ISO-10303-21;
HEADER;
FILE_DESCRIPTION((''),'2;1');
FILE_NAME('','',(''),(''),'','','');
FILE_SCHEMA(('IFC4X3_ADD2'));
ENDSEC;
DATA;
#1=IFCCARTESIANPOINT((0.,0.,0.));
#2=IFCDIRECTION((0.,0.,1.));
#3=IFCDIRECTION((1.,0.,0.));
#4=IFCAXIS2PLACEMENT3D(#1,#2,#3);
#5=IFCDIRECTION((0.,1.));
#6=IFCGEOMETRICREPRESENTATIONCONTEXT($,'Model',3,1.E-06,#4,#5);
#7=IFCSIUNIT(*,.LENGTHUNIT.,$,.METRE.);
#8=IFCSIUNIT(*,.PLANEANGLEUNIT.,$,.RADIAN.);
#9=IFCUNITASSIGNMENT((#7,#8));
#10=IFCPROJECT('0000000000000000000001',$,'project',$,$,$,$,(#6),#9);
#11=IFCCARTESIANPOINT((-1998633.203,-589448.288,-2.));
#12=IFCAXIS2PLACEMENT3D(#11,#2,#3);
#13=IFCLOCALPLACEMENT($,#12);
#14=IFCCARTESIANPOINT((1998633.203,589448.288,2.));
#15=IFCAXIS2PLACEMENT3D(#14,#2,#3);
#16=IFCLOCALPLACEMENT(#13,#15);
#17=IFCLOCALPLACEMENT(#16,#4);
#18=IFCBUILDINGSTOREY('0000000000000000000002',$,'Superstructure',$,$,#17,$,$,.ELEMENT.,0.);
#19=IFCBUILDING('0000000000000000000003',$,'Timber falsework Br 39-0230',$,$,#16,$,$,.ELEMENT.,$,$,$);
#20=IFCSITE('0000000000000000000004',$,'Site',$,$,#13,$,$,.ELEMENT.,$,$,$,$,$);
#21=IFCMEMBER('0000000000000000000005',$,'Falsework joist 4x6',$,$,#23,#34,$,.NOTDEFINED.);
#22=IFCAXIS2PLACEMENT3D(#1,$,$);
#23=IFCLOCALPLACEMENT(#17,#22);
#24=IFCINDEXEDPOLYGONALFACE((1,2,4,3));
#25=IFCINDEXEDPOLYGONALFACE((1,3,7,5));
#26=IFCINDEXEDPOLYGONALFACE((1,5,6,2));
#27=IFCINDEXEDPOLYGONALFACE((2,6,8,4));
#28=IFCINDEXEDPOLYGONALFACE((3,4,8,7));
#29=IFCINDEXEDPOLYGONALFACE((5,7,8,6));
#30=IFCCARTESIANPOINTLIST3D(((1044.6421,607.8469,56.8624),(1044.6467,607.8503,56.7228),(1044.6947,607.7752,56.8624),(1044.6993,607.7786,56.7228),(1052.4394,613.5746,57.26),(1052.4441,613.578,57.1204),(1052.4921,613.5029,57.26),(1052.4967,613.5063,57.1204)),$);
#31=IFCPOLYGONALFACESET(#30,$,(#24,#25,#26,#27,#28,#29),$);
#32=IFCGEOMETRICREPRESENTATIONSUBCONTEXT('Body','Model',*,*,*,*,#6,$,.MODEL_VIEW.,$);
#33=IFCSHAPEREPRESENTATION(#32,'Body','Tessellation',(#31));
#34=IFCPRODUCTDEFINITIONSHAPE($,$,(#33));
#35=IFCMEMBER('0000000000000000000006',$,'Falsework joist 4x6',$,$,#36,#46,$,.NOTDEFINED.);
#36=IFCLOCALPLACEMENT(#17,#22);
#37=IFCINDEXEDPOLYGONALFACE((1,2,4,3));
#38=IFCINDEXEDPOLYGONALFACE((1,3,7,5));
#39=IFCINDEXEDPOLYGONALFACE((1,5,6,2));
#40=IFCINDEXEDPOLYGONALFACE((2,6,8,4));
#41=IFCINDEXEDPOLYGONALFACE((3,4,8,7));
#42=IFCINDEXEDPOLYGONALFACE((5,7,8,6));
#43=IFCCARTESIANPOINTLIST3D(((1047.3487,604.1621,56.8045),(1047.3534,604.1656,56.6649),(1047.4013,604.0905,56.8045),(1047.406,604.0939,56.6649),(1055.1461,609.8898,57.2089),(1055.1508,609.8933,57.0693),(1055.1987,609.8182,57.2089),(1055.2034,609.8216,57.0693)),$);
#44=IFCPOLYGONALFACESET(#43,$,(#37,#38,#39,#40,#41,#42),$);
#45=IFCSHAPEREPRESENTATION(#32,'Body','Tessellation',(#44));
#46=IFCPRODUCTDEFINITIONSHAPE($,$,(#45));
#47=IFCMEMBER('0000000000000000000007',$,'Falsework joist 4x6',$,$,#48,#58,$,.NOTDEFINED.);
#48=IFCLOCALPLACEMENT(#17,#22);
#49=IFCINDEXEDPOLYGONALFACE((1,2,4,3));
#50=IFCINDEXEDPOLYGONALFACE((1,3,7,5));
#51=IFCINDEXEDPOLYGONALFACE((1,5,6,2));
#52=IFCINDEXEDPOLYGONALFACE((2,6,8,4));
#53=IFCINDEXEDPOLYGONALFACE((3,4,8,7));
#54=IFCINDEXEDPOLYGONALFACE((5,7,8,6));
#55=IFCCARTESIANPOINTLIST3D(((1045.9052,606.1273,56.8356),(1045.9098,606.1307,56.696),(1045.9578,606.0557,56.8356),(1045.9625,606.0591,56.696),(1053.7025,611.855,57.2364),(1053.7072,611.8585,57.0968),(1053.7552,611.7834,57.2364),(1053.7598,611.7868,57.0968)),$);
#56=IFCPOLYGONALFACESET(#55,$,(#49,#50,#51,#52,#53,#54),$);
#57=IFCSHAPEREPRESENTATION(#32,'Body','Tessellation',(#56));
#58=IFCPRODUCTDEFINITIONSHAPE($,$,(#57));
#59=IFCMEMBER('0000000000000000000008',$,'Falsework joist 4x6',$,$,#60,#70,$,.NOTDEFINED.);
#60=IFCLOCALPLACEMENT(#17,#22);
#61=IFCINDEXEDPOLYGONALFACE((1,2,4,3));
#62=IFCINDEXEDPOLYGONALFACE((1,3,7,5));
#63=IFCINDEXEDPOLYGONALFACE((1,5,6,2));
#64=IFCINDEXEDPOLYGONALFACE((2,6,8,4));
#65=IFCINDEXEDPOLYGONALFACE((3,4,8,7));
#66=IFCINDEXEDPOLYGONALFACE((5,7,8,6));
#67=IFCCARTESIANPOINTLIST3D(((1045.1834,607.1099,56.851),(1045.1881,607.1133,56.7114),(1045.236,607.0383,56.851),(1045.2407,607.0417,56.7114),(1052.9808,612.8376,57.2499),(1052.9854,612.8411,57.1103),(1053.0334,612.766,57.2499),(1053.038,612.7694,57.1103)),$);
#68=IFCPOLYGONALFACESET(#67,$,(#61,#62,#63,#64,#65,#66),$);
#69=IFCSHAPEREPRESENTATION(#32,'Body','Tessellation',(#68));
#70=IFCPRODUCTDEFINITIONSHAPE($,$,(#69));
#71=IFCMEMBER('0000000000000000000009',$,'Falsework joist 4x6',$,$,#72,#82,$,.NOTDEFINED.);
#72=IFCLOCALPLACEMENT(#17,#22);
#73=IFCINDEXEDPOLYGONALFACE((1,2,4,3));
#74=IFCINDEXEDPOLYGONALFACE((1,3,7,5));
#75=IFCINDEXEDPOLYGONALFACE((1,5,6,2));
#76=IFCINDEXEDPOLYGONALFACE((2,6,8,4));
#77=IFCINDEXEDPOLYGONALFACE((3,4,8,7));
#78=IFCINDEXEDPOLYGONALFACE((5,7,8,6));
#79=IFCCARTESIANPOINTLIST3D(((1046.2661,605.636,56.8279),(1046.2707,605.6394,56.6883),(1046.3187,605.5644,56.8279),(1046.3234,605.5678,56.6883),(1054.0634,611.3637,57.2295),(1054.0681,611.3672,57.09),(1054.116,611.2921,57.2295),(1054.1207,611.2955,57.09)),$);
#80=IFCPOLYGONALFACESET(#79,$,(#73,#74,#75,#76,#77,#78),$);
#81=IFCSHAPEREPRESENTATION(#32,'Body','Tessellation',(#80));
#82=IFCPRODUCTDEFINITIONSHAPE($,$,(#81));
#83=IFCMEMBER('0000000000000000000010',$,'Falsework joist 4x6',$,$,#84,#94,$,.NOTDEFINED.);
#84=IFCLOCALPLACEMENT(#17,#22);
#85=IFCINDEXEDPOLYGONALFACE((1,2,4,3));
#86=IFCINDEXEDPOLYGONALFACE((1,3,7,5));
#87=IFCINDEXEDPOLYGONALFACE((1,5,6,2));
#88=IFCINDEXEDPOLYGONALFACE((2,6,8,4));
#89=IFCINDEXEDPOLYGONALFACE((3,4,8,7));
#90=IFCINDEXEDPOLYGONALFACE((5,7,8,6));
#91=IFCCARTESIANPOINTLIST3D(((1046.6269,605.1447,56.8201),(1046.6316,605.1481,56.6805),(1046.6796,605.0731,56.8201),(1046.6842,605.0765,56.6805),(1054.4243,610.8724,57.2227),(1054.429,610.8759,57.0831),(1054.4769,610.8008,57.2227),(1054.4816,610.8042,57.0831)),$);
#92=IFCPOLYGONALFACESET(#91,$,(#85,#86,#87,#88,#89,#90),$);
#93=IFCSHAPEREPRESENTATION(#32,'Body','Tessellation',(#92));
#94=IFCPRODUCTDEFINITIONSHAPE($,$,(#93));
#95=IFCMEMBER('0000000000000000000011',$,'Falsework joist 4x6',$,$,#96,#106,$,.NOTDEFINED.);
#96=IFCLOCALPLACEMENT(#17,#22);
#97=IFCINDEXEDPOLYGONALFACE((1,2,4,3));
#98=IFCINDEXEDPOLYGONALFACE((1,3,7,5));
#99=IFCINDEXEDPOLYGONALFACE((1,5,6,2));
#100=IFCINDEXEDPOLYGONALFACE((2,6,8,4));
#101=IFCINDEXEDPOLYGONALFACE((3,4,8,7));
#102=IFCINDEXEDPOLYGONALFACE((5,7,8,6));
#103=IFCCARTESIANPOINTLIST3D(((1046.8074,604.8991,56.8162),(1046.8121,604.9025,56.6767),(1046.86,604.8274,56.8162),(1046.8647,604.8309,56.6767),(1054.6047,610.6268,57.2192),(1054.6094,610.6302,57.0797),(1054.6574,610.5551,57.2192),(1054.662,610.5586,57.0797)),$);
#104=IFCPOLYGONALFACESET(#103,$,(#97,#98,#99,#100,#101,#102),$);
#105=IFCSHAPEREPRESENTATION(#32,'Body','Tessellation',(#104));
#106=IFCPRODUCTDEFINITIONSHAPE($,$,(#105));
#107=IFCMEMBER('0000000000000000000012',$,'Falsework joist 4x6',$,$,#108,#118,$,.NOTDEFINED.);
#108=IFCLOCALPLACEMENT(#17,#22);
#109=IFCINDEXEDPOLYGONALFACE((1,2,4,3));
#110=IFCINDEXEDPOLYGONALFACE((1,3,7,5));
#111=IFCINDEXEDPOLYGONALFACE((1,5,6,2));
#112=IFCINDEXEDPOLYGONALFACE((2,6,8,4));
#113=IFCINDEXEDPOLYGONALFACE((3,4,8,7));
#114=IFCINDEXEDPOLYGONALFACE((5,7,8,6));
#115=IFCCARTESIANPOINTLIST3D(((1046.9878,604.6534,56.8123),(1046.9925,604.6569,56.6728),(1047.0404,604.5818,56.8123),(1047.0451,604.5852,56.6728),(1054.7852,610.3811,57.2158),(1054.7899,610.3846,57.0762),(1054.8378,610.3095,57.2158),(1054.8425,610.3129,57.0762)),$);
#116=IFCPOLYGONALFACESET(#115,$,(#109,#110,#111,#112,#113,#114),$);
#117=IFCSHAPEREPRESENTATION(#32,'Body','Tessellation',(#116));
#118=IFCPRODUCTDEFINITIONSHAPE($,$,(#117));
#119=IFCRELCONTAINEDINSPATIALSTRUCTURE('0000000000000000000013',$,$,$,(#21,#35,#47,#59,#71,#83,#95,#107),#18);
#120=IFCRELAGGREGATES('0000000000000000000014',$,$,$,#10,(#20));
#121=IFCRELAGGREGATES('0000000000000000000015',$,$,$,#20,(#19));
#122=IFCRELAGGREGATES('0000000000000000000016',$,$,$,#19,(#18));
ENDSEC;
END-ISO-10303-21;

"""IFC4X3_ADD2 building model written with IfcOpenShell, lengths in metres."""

from ifc_helpers import new_model, si_unit, direction, frame, frame_2d, origin, origin_with_axes, place, context, subcontext, project, spatial, rectangle, extrude, element, save


model = new_model("IFC4X3_ADD2")

# Units and contexts
model_context = context("Model", 3, precision=1e-06, world=origin_with_axes(), true_north=direction((0.0, 1.0)))
body_context = subcontext(model_context, "Body", "Model", "MODEL_VIEW")
ifc_project = project(units=[si_unit("LENGTHUNIT", "METRE"), si_unit("PLANEANGLEUNIT", "RADIAN")], contexts=[model_context])

# Site, building, storey
site_placement = place(None, frame((-1998633.203, -589448.288, -2.0), z_axis=(0.0, 0.0, 1.0), x_axis=(1.0, 0.0, 0.0)))
site = spatial("IfcSite", under=ifc_project, at=site_placement, Name="Site", CompositionType="ELEMENT")
building_placement = place(site_placement, frame((1998633.203, 589448.288, 2.0), z_axis=(0.0, 0.0, 1.0), x_axis=(1.0, 0.0, 0.0)))
building = spatial("IfcBuilding", under=site, at=building_placement, Name="Timber falsework Br 39-0230", CompositionType="ELEMENT")
storey_placement = place(building_placement, origin_with_axes())
storey = spatial("IfcBuildingStorey", under=building, at=storey_placement, Name="Superstructure", CompositionType="ELEMENT", Elevation=0.0)

# Members
member_1_placement = place(storey_placement, frame((1044.673, 607.8144, 56.7228), z_axis=(0.805249, 0.591514, 0.041057), x_axis=(-0.592013, 0.805928, 0.0)))
element("IfcMember", 1, at=member_1_placement, inside=storey, Name="Falsework joist 4x6", PredefinedType="NOTDEFINED", context=body_context, shape_type="SweptSolid", body=[
    extrude(rectangle(XDim=0.0889, YDim=0.1397, at=frame_2d((0.0, 0.0698))), origin(), (0.0, 0.0, 1.0), 9.6832),
])
member_2_placement = place(storey_placement, frame((1047.3797, 604.1297, 56.6649), z_axis=(0.805225, 0.591497, 0.04176), x_axis=(-0.592013, 0.805928, 0.0)))
element("IfcMember", 2, at=member_2_placement, inside=storey, Name="Falsework joist 4x6", PredefinedType="NOTDEFINED", context=body_context, shape_type="SweptSolid", body=[
    extrude(rectangle(XDim=0.0889, YDim=0.1397, at=frame_2d((0.0, 0.0698))), origin(), (0.0, 0.0, 1.0), 9.6834),
])
member_3_placement = place(storey_placement, frame((1045.9362, 606.0949, 56.696), z_axis=(0.805238, 0.591506, 0.041385), x_axis=(-0.592013, 0.805928, 0.0)))
element("IfcMember", 3, at=member_3_placement, inside=storey, Name="Falsework joist 4x6", PredefinedType="NOTDEFINED", context=body_context, shape_type="SweptSolid", body=[
    extrude(rectangle(XDim=0.0889, YDim=0.1397, at=frame_2d((0.0, 0.0698))), origin(), (0.0, 0.0, 1.0), 9.6833),
])
member_4_placement = place(storey_placement, frame((1045.2144, 607.0775, 56.7114), z_axis=(0.805244, 0.591511, 0.041197), x_axis=(-0.592013, 0.805928, 0.0)))
element("IfcMember", 4, at=member_4_placement, inside=storey, Name="Falsework joist 4x6", PredefinedType="NOTDEFINED", context=body_context, shape_type="SweptSolid", body=[
    extrude(rectangle(XDim=0.0889, YDim=0.1397, at=frame_2d((0.0, 0.0698))), origin(), (0.0, 0.0, 1.0), 9.6832),
])
member_5_placement = place(storey_placement, frame((1046.297, 605.6036, 56.6883), z_axis=(0.805235, 0.591504, 0.041479), x_axis=(-0.592013, 0.805928, 0.0)))
element("IfcMember", 5, at=member_5_placement, inside=storey, Name="Falsework joist 4x6", PredefinedType="NOTDEFINED", context=body_context, shape_type="SweptSolid", body=[
    extrude(rectangle(XDim=0.0889, YDim=0.1397, at=frame_2d((0.0, 0.0698))), origin(), (0.0, 0.0, 1.0), 9.6833),
])
member_6_placement = place(storey_placement, frame((1046.6579, 605.1123, 56.6805), z_axis=(0.805232, 0.591501, 0.041572), x_axis=(-0.592013, 0.805928, 0.0)))
element("IfcMember", 6, at=member_6_placement, inside=storey, Name="Falsework joist 4x6", PredefinedType="NOTDEFINED", context=body_context, shape_type="SweptSolid", body=[
    extrude(rectangle(XDim=0.0889, YDim=0.1397, at=frame_2d((0.0, 0.0698))), origin(), (0.0, 0.0, 1.0), 9.6834),
])
member_7_placement = place(storey_placement, frame((1046.8384, 604.8667, 56.6767), z_axis=(0.80523, 0.5915, 0.041619), x_axis=(-0.592013, 0.805928, 0.0)))
element("IfcMember", 7, at=member_7_placement, inside=storey, Name="Falsework joist 4x6", PredefinedType="NOTDEFINED", context=body_context, shape_type="SweptSolid", body=[
    extrude(rectangle(XDim=0.0889, YDim=0.1397, at=frame_2d((0.0, 0.0698))), origin(), (0.0, 0.0, 1.0), 9.6834),
])
member_8_placement = place(storey_placement, frame((1047.0188, 604.621, 56.6728), z_axis=(0.805228, 0.591499, 0.041666), x_axis=(-0.592013, 0.805928, 0.0)))
element("IfcMember", 8, at=member_8_placement, inside=storey, Name="Falsework joist 4x6", PredefinedType="NOTDEFINED", context=body_context, shape_type="SweptSolid", body=[
    extrude(rectangle(XDim=0.0889, YDim=0.1397, at=frame_2d((0.0, 0.0698))), origin(), (0.0, 0.0, 1.0), 9.6834),
])

save(model, "model.ifc")
